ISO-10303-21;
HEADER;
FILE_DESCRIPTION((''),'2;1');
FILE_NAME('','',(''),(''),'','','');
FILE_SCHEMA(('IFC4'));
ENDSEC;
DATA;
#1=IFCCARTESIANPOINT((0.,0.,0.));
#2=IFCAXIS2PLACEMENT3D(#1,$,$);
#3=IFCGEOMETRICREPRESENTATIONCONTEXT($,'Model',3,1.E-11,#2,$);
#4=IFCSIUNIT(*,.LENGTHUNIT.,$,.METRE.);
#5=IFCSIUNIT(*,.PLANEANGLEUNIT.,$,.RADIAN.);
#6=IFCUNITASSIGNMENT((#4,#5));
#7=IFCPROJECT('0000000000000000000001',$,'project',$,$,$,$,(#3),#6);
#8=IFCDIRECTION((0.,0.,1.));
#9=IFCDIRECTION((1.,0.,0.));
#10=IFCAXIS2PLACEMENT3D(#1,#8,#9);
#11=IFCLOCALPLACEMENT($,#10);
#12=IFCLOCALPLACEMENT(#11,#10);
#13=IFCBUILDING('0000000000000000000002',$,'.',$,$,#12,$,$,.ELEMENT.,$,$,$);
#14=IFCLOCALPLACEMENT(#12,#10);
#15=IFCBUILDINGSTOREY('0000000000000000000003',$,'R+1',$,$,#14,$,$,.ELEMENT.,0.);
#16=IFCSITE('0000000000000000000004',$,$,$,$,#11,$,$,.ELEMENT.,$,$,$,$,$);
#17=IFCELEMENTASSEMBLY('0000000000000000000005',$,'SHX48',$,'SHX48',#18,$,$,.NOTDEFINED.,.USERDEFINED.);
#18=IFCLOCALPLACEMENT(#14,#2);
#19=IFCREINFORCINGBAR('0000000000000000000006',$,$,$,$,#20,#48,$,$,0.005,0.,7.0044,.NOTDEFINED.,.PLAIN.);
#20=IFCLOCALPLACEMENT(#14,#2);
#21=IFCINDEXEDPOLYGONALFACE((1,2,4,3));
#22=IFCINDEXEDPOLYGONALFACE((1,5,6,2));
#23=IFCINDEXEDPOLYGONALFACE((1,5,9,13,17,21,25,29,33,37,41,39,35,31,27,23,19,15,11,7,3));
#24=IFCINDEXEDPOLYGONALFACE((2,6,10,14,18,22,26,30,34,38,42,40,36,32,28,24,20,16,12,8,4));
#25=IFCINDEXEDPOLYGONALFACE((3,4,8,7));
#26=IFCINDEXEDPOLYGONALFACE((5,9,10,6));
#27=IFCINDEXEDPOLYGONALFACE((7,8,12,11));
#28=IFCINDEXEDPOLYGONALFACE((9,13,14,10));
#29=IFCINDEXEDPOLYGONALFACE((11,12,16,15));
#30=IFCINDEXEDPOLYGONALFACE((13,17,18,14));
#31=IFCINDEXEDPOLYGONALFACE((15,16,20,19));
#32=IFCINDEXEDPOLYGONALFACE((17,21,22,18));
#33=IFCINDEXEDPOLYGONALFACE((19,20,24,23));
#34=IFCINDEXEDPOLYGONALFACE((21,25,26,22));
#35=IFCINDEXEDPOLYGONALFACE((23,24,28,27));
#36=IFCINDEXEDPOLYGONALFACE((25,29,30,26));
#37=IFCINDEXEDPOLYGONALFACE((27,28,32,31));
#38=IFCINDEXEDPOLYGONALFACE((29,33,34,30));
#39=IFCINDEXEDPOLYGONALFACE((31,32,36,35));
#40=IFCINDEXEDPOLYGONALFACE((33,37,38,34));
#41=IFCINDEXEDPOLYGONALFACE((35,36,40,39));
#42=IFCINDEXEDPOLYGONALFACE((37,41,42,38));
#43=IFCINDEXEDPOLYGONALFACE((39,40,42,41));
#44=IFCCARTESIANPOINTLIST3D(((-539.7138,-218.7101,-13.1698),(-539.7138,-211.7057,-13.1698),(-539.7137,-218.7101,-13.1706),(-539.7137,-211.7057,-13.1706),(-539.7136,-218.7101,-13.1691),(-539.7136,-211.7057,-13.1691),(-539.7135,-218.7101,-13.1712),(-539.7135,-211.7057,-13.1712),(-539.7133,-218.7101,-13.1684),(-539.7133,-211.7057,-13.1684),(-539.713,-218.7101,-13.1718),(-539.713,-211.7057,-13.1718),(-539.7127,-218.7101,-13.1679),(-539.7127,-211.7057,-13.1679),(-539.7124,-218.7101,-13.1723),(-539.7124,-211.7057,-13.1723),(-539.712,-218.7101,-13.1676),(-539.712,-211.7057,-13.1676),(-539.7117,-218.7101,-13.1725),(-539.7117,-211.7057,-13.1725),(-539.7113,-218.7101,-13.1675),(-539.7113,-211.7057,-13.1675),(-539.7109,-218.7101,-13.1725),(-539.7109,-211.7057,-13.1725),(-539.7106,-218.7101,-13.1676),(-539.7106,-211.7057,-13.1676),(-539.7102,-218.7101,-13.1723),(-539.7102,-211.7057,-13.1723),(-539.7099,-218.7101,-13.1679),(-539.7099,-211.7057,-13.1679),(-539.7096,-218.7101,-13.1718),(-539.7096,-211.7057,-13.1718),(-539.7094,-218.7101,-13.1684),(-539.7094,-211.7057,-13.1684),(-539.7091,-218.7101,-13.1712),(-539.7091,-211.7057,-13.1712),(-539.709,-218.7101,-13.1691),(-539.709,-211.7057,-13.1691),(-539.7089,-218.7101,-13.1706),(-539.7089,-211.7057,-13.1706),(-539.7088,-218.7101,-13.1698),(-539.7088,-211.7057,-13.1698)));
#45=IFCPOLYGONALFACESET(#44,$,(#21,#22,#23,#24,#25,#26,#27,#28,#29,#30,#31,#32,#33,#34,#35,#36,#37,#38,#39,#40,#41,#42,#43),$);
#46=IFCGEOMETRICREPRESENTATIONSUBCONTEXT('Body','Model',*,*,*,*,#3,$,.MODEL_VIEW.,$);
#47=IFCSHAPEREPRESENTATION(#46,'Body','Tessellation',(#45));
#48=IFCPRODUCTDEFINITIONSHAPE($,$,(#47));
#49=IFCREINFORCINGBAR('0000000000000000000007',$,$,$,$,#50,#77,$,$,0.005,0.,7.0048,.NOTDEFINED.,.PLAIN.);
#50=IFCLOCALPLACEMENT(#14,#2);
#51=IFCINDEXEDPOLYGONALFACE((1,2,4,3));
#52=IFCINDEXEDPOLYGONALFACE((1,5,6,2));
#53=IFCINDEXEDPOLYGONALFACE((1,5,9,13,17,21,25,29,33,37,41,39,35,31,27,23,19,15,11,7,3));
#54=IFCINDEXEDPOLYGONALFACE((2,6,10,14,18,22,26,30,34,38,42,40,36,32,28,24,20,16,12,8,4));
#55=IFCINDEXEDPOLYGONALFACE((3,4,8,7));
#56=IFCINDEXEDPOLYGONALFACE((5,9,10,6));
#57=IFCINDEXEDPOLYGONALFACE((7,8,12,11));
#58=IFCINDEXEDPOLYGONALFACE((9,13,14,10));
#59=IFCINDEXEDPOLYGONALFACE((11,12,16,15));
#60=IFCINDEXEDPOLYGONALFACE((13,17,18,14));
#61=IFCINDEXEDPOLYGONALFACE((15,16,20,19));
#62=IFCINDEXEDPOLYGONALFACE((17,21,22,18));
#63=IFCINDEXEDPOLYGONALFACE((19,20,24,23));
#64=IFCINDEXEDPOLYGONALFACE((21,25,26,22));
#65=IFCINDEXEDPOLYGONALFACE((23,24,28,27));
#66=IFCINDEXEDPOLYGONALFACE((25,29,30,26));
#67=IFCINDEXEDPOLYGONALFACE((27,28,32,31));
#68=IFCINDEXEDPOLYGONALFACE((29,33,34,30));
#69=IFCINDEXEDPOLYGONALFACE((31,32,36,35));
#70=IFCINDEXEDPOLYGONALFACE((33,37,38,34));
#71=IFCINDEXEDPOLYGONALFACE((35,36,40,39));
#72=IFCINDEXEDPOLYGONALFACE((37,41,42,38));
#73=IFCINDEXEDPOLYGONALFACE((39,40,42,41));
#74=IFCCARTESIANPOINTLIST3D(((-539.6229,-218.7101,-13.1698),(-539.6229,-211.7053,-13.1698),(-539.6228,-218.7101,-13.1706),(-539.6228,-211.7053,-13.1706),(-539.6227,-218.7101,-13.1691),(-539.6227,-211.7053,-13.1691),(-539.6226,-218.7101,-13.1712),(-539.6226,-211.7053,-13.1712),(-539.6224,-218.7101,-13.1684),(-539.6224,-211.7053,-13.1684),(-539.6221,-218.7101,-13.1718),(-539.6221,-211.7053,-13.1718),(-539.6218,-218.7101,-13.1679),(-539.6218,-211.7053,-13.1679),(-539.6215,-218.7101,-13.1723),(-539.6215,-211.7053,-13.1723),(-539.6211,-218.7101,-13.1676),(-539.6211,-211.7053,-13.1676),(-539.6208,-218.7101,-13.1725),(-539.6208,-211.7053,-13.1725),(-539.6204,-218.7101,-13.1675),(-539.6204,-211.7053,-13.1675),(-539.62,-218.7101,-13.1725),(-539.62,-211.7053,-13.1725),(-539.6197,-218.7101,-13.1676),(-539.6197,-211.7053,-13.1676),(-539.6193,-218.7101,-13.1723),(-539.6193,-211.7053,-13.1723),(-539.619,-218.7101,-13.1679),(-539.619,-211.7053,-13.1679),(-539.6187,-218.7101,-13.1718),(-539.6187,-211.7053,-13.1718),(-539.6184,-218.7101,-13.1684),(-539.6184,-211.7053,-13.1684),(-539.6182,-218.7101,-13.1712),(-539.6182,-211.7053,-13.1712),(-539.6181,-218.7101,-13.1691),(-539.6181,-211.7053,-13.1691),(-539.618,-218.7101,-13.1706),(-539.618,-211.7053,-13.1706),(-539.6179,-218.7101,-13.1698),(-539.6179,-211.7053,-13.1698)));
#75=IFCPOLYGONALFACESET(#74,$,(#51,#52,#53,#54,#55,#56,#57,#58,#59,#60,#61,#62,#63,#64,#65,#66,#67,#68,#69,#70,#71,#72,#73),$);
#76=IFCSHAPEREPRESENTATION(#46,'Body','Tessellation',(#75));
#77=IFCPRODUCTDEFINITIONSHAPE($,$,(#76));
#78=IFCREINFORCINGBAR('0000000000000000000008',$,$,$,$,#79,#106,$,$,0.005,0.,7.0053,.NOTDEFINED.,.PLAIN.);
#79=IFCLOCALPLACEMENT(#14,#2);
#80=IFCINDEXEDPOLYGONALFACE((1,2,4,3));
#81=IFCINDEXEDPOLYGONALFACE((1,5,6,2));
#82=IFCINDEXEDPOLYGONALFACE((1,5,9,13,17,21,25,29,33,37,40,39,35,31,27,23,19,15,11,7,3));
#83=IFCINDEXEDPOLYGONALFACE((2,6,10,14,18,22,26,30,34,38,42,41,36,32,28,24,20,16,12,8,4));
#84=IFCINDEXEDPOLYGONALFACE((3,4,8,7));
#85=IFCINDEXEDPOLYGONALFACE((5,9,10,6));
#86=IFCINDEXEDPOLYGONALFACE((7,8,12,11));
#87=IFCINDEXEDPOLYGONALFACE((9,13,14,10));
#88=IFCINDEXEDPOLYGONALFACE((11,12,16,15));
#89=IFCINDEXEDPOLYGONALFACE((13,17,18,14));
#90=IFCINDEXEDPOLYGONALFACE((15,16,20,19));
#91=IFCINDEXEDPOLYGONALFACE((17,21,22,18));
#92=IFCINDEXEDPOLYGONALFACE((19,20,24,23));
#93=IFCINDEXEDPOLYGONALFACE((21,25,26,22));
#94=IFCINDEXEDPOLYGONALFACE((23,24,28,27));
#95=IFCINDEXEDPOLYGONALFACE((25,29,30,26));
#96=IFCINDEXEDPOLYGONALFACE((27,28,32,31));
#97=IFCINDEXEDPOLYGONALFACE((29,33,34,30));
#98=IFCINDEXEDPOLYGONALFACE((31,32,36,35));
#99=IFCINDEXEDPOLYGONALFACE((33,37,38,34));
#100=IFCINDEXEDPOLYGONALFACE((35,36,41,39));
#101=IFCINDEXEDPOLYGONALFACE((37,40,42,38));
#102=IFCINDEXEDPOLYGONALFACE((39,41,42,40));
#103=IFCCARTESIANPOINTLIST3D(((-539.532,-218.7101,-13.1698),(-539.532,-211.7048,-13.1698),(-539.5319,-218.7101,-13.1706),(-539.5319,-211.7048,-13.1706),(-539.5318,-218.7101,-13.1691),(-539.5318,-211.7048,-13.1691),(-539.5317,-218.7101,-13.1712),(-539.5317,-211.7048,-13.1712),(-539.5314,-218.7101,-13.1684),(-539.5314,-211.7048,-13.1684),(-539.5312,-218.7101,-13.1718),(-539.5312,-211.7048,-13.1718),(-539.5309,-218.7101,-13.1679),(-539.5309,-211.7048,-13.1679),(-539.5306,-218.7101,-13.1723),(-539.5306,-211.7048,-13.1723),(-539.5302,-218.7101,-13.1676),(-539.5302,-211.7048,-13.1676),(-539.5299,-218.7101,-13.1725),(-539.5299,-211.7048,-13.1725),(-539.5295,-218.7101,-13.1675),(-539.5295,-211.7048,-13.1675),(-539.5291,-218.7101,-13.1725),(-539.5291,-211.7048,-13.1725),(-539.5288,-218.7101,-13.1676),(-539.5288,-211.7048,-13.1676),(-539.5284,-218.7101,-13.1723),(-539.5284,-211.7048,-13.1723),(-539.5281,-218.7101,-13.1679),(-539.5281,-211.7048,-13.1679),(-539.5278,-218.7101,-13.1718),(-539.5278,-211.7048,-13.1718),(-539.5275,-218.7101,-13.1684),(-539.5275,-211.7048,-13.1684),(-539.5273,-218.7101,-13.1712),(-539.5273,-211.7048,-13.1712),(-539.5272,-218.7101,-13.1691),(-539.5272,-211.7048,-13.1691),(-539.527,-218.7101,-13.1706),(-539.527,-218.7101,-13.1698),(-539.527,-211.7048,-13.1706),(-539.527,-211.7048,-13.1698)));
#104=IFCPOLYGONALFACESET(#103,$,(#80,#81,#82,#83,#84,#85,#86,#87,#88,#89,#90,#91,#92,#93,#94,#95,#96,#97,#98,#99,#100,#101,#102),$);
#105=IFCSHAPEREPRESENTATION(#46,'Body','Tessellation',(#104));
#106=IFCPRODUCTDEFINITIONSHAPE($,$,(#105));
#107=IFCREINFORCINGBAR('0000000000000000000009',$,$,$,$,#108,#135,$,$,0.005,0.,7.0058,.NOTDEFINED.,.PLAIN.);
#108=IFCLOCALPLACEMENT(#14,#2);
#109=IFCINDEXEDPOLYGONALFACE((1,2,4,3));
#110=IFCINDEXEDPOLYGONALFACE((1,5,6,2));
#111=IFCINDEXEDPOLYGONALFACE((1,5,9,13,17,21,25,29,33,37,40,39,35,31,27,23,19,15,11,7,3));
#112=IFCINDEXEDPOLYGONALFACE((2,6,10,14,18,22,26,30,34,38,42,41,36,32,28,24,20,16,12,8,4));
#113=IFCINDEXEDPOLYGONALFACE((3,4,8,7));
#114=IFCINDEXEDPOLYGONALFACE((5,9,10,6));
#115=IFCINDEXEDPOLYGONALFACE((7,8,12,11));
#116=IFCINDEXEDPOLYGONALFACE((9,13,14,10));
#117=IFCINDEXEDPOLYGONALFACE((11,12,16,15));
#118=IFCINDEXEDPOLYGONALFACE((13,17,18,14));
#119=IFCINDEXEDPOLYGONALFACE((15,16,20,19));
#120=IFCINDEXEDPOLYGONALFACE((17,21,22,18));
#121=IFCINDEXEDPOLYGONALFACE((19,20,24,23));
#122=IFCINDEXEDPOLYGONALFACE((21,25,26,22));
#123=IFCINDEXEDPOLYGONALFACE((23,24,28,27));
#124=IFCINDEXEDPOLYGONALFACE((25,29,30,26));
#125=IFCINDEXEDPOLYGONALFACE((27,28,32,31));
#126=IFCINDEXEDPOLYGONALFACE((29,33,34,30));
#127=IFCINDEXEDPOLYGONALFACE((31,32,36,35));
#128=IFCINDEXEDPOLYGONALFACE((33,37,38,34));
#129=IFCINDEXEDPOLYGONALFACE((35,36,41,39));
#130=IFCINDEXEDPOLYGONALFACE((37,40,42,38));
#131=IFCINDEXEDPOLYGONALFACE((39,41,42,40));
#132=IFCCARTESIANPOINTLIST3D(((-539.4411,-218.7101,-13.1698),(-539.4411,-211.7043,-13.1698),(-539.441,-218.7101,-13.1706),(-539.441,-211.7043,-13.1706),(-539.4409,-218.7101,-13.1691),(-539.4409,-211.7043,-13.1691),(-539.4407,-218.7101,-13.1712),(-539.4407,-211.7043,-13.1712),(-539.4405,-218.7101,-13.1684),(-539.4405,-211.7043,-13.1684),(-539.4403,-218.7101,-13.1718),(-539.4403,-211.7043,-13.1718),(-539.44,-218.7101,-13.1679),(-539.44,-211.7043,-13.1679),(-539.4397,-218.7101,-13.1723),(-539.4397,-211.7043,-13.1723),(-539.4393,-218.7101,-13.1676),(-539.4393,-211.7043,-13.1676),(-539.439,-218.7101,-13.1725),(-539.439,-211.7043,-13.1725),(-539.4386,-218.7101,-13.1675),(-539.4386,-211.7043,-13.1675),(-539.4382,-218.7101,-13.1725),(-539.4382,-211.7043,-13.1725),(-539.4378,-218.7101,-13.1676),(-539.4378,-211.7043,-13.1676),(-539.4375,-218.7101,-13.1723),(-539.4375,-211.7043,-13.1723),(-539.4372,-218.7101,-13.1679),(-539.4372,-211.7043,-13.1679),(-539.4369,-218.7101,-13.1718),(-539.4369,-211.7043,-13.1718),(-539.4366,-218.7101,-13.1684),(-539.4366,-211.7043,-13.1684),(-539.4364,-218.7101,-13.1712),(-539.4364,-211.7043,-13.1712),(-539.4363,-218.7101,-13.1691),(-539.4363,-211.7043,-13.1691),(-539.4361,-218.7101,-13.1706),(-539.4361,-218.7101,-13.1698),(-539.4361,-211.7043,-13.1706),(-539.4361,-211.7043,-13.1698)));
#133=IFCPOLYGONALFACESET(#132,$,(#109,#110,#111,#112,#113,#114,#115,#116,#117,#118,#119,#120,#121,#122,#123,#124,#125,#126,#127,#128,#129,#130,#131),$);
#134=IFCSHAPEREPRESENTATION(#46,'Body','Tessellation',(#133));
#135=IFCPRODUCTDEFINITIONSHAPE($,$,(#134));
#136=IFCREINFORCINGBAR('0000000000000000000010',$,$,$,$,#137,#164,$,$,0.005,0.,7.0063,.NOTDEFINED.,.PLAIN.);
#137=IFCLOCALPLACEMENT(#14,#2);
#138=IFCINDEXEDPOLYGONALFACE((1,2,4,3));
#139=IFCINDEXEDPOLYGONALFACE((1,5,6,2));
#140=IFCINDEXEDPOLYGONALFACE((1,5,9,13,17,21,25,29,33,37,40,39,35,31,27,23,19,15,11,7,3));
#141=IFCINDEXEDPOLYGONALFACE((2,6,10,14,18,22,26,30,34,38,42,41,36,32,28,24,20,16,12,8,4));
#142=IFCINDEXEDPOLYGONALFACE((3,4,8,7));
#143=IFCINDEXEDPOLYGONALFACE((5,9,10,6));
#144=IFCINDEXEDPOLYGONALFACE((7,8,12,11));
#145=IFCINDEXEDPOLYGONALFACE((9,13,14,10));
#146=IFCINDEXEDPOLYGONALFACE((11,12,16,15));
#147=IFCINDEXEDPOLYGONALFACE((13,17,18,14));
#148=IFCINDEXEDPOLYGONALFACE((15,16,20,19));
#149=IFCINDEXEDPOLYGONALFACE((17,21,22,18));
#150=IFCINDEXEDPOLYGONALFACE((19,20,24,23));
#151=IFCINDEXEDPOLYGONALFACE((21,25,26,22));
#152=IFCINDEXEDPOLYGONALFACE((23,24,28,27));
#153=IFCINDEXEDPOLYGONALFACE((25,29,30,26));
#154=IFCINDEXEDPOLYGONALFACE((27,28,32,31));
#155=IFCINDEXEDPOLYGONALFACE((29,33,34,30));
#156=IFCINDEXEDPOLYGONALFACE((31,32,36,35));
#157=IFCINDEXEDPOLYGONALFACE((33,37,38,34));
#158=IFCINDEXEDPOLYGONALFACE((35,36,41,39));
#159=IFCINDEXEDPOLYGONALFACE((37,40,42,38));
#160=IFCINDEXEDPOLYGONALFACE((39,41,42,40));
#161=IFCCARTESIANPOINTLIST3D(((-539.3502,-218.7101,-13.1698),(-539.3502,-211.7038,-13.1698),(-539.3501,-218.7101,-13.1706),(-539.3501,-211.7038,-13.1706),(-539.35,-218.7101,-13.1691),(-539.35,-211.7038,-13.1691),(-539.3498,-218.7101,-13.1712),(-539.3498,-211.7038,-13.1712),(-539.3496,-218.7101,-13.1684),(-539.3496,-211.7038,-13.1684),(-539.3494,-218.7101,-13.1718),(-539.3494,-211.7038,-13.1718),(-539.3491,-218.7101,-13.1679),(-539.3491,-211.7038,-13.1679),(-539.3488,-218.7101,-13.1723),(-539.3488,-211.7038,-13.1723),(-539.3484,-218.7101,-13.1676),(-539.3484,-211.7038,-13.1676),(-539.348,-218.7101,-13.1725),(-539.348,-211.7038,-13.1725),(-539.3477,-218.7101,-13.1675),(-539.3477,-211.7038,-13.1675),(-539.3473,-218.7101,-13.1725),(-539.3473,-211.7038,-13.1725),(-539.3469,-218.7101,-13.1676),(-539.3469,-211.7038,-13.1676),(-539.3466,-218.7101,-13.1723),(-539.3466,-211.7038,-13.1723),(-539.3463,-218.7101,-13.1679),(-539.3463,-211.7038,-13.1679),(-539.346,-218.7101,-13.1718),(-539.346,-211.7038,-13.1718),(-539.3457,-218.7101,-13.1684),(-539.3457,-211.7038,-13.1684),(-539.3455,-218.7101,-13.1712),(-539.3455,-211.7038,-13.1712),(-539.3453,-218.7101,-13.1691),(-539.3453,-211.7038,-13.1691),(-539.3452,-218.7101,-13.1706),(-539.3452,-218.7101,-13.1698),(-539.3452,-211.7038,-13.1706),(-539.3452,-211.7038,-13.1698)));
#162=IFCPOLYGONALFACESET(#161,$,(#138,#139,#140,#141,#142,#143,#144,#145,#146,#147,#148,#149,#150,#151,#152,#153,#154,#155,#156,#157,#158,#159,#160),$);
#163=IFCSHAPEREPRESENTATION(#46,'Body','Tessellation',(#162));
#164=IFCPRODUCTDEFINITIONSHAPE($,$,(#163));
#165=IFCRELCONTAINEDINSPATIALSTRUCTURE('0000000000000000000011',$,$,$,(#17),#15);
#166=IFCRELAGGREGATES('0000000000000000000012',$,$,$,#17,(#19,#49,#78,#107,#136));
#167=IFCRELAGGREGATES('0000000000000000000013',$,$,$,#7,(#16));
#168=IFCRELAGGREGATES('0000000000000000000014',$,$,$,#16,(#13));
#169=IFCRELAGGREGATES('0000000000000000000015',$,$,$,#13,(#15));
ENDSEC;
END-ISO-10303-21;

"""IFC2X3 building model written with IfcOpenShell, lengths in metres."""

from ifc_helpers import new_model, entity, si_unit, origin, origin_with_axes, place, context, subcontext, project, spatial, shape, element, aggregate, save


model = new_model("IFC2X3")

# Units and contexts
model_context = context("Model", 3, precision=1e-11, world=origin())
body_context = subcontext(model_context, "Body", "Model", "MODEL_VIEW")
ifc_project = project(units=[si_unit("LENGTHUNIT", "METRE"), si_unit("PLANEANGLEUNIT", "RADIAN")], contexts=[model_context])

# Site, building, storey
site_placement = place(None, origin_with_axes())
site = spatial("IfcSite", under=ifc_project, at=site_placement, CompositionType="ELEMENT")
building_placement = place(site_placement, origin_with_axes())
building = spatial("IfcBuilding", under=site, at=building_placement, Name=".", CompositionType="ELEMENT")
storey_placement = place(building_placement, origin_with_axes())
storey = spatial("IfcBuildingStorey", under=building, at=storey_placement, Name="R+1", CompositionType="ELEMENT", Elevation=0.0)

# Element assembly, reinforcing bars
assembly_1_placement = place(storey_placement, origin_with_axes())
assembly_1 = element("IfcElementAssembly", 1, at=assembly_1_placement, inside=storey, Name="SHX48", ObjectType="SHX48", AssemblyPlace="NOTDEFINED", PredefinedType="USERDEFINED")
reinforcing_bar_1_placement = place(assembly_1_placement, origin_with_axes())
reinforcing_bar_1 = element("IfcReinforcingBar", 2, at=reinforcing_bar_1_placement, BarLength=7.0044, BarRole="NOTDEFINED", BarSurface="PLAIN", CrossSectionArea=0.0, NominalDiameter=0.005, shapes=[
    shape(body_context, "Body", "AdvancedSweptSolid", [entity("IfcSweptDiskSolid", entity("IfcPolyline", [entity("IfcCartesianPoint", [539.7113, 211.7057, 13.17]), entity("IfcCartesianPoint", [539.7113, 218.7101, 13.17])]), 0.0025, None, 0.0, 7.0044)]),
    shape(body_context, "Body", "AdvancedSweptSolid", [entity("IfcSweptDiskSolid", entity("IfcPolyline", [entity("IfcCartesianPoint", [539.7113, 211.7057, 13.17]), entity("IfcCartesianPoint", [539.7113, 218.7101, 13.17])]), 0.0025, None, 0.0, 7.0044)]),
])
reinforcing_bar_2_placement = place(assembly_1_placement, origin_with_axes())
reinforcing_bar_2 = element("IfcReinforcingBar", 3, at=reinforcing_bar_2_placement, BarLength=7.0048, BarRole="NOTDEFINED", BarSurface="PLAIN", CrossSectionArea=0.0, NominalDiameter=0.005, shapes=[
    shape(body_context, "Body", "AdvancedSweptSolid", [entity("IfcSweptDiskSolid", entity("IfcPolyline", [entity("IfcCartesianPoint", [539.6204, 211.7053, 13.17]), entity("IfcCartesianPoint", [539.6204, 218.7101, 13.17])]), 0.0025, None, 0.0, 7.0048)]),
    shape(body_context, "Body", "AdvancedSweptSolid", [entity("IfcSweptDiskSolid", entity("IfcPolyline", [entity("IfcCartesianPoint", [539.6204, 211.7053, 13.17]), entity("IfcCartesianPoint", [539.6204, 218.7101, 13.17])]), 0.0025, None, 0.0, 7.0048)]),
])
reinforcing_bar_3_placement = place(assembly_1_placement, origin_with_axes())
reinforcing_bar_3 = element("IfcReinforcingBar", 4, at=reinforcing_bar_3_placement, BarLength=7.0053, BarRole="NOTDEFINED", BarSurface="PLAIN", CrossSectionArea=0.0, NominalDiameter=0.005, shapes=[
    shape(body_context, "Body", "AdvancedSweptSolid", [entity("IfcSweptDiskSolid", entity("IfcPolyline", [entity("IfcCartesianPoint", [539.5295, 211.7048, 13.17]), entity("IfcCartesianPoint", [539.5295, 218.7101, 13.17])]), 0.0025, None, 0.0, 7.0053)]),
    shape(body_context, "Body", "AdvancedSweptSolid", [entity("IfcSweptDiskSolid", entity("IfcPolyline", [entity("IfcCartesianPoint", [539.5295, 211.7048, 13.17]), entity("IfcCartesianPoint", [539.5295, 218.7101, 13.17])]), 0.0025, None, 0.0, 7.0053)]),
])
reinforcing_bar_4_placement = place(assembly_1_placement, origin_with_axes())
reinforcing_bar_4 = element("IfcReinforcingBar", 5, at=reinforcing_bar_4_placement, BarLength=7.0058, BarRole="NOTDEFINED", BarSurface="PLAIN", CrossSectionArea=0.0, NominalDiameter=0.005, shapes=[
    shape(body_context, "Body", "AdvancedSweptSolid", [entity("IfcSweptDiskSolid", entity("IfcPolyline", [entity("IfcCartesianPoint", [539.4386, 211.7043, 13.17]), entity("IfcCartesianPoint", [539.4386, 218.7101, 13.17])]), 0.0025, None, 0.0, 7.0058)]),
    shape(body_context, "Body", "AdvancedSweptSolid", [entity("IfcSweptDiskSolid", entity("IfcPolyline", [entity("IfcCartesianPoint", [539.4386, 211.7043, 13.17]), entity("IfcCartesianPoint", [539.4386, 218.7101, 13.17])]), 0.0025, None, 0.0, 7.0058)]),
])
reinforcing_bar_5_placement = place(assembly_1_placement, origin_with_axes())
reinforcing_bar_5 = element("IfcReinforcingBar", 6, at=reinforcing_bar_5_placement, BarLength=7.0063, BarRole="NOTDEFINED", BarSurface="PLAIN", CrossSectionArea=0.0, NominalDiameter=0.005, shapes=[
    shape(body_context, "Body", "AdvancedSweptSolid", [entity("IfcSweptDiskSolid", entity("IfcPolyline", [entity("IfcCartesianPoint", [539.3477, 211.7038, 13.17]), entity("IfcCartesianPoint", [539.3477, 218.7101, 13.17])]), 0.0025, None, 0.0, 7.0063)]),
    shape(body_context, "Body", "AdvancedSweptSolid", [entity("IfcSweptDiskSolid", entity("IfcPolyline", [entity("IfcCartesianPoint", [539.3477, 211.7038, 13.17]), entity("IfcCartesianPoint", [539.3477, 218.7101, 13.17])]), 0.0025, None, 0.0, 7.0063)]),
])
aggregate(assembly_1, [reinforcing_bar_1, reinforcing_bar_2, reinforcing_bar_3, reinforcing_bar_4, reinforcing_bar_5])

save(model, "model.ifc")
